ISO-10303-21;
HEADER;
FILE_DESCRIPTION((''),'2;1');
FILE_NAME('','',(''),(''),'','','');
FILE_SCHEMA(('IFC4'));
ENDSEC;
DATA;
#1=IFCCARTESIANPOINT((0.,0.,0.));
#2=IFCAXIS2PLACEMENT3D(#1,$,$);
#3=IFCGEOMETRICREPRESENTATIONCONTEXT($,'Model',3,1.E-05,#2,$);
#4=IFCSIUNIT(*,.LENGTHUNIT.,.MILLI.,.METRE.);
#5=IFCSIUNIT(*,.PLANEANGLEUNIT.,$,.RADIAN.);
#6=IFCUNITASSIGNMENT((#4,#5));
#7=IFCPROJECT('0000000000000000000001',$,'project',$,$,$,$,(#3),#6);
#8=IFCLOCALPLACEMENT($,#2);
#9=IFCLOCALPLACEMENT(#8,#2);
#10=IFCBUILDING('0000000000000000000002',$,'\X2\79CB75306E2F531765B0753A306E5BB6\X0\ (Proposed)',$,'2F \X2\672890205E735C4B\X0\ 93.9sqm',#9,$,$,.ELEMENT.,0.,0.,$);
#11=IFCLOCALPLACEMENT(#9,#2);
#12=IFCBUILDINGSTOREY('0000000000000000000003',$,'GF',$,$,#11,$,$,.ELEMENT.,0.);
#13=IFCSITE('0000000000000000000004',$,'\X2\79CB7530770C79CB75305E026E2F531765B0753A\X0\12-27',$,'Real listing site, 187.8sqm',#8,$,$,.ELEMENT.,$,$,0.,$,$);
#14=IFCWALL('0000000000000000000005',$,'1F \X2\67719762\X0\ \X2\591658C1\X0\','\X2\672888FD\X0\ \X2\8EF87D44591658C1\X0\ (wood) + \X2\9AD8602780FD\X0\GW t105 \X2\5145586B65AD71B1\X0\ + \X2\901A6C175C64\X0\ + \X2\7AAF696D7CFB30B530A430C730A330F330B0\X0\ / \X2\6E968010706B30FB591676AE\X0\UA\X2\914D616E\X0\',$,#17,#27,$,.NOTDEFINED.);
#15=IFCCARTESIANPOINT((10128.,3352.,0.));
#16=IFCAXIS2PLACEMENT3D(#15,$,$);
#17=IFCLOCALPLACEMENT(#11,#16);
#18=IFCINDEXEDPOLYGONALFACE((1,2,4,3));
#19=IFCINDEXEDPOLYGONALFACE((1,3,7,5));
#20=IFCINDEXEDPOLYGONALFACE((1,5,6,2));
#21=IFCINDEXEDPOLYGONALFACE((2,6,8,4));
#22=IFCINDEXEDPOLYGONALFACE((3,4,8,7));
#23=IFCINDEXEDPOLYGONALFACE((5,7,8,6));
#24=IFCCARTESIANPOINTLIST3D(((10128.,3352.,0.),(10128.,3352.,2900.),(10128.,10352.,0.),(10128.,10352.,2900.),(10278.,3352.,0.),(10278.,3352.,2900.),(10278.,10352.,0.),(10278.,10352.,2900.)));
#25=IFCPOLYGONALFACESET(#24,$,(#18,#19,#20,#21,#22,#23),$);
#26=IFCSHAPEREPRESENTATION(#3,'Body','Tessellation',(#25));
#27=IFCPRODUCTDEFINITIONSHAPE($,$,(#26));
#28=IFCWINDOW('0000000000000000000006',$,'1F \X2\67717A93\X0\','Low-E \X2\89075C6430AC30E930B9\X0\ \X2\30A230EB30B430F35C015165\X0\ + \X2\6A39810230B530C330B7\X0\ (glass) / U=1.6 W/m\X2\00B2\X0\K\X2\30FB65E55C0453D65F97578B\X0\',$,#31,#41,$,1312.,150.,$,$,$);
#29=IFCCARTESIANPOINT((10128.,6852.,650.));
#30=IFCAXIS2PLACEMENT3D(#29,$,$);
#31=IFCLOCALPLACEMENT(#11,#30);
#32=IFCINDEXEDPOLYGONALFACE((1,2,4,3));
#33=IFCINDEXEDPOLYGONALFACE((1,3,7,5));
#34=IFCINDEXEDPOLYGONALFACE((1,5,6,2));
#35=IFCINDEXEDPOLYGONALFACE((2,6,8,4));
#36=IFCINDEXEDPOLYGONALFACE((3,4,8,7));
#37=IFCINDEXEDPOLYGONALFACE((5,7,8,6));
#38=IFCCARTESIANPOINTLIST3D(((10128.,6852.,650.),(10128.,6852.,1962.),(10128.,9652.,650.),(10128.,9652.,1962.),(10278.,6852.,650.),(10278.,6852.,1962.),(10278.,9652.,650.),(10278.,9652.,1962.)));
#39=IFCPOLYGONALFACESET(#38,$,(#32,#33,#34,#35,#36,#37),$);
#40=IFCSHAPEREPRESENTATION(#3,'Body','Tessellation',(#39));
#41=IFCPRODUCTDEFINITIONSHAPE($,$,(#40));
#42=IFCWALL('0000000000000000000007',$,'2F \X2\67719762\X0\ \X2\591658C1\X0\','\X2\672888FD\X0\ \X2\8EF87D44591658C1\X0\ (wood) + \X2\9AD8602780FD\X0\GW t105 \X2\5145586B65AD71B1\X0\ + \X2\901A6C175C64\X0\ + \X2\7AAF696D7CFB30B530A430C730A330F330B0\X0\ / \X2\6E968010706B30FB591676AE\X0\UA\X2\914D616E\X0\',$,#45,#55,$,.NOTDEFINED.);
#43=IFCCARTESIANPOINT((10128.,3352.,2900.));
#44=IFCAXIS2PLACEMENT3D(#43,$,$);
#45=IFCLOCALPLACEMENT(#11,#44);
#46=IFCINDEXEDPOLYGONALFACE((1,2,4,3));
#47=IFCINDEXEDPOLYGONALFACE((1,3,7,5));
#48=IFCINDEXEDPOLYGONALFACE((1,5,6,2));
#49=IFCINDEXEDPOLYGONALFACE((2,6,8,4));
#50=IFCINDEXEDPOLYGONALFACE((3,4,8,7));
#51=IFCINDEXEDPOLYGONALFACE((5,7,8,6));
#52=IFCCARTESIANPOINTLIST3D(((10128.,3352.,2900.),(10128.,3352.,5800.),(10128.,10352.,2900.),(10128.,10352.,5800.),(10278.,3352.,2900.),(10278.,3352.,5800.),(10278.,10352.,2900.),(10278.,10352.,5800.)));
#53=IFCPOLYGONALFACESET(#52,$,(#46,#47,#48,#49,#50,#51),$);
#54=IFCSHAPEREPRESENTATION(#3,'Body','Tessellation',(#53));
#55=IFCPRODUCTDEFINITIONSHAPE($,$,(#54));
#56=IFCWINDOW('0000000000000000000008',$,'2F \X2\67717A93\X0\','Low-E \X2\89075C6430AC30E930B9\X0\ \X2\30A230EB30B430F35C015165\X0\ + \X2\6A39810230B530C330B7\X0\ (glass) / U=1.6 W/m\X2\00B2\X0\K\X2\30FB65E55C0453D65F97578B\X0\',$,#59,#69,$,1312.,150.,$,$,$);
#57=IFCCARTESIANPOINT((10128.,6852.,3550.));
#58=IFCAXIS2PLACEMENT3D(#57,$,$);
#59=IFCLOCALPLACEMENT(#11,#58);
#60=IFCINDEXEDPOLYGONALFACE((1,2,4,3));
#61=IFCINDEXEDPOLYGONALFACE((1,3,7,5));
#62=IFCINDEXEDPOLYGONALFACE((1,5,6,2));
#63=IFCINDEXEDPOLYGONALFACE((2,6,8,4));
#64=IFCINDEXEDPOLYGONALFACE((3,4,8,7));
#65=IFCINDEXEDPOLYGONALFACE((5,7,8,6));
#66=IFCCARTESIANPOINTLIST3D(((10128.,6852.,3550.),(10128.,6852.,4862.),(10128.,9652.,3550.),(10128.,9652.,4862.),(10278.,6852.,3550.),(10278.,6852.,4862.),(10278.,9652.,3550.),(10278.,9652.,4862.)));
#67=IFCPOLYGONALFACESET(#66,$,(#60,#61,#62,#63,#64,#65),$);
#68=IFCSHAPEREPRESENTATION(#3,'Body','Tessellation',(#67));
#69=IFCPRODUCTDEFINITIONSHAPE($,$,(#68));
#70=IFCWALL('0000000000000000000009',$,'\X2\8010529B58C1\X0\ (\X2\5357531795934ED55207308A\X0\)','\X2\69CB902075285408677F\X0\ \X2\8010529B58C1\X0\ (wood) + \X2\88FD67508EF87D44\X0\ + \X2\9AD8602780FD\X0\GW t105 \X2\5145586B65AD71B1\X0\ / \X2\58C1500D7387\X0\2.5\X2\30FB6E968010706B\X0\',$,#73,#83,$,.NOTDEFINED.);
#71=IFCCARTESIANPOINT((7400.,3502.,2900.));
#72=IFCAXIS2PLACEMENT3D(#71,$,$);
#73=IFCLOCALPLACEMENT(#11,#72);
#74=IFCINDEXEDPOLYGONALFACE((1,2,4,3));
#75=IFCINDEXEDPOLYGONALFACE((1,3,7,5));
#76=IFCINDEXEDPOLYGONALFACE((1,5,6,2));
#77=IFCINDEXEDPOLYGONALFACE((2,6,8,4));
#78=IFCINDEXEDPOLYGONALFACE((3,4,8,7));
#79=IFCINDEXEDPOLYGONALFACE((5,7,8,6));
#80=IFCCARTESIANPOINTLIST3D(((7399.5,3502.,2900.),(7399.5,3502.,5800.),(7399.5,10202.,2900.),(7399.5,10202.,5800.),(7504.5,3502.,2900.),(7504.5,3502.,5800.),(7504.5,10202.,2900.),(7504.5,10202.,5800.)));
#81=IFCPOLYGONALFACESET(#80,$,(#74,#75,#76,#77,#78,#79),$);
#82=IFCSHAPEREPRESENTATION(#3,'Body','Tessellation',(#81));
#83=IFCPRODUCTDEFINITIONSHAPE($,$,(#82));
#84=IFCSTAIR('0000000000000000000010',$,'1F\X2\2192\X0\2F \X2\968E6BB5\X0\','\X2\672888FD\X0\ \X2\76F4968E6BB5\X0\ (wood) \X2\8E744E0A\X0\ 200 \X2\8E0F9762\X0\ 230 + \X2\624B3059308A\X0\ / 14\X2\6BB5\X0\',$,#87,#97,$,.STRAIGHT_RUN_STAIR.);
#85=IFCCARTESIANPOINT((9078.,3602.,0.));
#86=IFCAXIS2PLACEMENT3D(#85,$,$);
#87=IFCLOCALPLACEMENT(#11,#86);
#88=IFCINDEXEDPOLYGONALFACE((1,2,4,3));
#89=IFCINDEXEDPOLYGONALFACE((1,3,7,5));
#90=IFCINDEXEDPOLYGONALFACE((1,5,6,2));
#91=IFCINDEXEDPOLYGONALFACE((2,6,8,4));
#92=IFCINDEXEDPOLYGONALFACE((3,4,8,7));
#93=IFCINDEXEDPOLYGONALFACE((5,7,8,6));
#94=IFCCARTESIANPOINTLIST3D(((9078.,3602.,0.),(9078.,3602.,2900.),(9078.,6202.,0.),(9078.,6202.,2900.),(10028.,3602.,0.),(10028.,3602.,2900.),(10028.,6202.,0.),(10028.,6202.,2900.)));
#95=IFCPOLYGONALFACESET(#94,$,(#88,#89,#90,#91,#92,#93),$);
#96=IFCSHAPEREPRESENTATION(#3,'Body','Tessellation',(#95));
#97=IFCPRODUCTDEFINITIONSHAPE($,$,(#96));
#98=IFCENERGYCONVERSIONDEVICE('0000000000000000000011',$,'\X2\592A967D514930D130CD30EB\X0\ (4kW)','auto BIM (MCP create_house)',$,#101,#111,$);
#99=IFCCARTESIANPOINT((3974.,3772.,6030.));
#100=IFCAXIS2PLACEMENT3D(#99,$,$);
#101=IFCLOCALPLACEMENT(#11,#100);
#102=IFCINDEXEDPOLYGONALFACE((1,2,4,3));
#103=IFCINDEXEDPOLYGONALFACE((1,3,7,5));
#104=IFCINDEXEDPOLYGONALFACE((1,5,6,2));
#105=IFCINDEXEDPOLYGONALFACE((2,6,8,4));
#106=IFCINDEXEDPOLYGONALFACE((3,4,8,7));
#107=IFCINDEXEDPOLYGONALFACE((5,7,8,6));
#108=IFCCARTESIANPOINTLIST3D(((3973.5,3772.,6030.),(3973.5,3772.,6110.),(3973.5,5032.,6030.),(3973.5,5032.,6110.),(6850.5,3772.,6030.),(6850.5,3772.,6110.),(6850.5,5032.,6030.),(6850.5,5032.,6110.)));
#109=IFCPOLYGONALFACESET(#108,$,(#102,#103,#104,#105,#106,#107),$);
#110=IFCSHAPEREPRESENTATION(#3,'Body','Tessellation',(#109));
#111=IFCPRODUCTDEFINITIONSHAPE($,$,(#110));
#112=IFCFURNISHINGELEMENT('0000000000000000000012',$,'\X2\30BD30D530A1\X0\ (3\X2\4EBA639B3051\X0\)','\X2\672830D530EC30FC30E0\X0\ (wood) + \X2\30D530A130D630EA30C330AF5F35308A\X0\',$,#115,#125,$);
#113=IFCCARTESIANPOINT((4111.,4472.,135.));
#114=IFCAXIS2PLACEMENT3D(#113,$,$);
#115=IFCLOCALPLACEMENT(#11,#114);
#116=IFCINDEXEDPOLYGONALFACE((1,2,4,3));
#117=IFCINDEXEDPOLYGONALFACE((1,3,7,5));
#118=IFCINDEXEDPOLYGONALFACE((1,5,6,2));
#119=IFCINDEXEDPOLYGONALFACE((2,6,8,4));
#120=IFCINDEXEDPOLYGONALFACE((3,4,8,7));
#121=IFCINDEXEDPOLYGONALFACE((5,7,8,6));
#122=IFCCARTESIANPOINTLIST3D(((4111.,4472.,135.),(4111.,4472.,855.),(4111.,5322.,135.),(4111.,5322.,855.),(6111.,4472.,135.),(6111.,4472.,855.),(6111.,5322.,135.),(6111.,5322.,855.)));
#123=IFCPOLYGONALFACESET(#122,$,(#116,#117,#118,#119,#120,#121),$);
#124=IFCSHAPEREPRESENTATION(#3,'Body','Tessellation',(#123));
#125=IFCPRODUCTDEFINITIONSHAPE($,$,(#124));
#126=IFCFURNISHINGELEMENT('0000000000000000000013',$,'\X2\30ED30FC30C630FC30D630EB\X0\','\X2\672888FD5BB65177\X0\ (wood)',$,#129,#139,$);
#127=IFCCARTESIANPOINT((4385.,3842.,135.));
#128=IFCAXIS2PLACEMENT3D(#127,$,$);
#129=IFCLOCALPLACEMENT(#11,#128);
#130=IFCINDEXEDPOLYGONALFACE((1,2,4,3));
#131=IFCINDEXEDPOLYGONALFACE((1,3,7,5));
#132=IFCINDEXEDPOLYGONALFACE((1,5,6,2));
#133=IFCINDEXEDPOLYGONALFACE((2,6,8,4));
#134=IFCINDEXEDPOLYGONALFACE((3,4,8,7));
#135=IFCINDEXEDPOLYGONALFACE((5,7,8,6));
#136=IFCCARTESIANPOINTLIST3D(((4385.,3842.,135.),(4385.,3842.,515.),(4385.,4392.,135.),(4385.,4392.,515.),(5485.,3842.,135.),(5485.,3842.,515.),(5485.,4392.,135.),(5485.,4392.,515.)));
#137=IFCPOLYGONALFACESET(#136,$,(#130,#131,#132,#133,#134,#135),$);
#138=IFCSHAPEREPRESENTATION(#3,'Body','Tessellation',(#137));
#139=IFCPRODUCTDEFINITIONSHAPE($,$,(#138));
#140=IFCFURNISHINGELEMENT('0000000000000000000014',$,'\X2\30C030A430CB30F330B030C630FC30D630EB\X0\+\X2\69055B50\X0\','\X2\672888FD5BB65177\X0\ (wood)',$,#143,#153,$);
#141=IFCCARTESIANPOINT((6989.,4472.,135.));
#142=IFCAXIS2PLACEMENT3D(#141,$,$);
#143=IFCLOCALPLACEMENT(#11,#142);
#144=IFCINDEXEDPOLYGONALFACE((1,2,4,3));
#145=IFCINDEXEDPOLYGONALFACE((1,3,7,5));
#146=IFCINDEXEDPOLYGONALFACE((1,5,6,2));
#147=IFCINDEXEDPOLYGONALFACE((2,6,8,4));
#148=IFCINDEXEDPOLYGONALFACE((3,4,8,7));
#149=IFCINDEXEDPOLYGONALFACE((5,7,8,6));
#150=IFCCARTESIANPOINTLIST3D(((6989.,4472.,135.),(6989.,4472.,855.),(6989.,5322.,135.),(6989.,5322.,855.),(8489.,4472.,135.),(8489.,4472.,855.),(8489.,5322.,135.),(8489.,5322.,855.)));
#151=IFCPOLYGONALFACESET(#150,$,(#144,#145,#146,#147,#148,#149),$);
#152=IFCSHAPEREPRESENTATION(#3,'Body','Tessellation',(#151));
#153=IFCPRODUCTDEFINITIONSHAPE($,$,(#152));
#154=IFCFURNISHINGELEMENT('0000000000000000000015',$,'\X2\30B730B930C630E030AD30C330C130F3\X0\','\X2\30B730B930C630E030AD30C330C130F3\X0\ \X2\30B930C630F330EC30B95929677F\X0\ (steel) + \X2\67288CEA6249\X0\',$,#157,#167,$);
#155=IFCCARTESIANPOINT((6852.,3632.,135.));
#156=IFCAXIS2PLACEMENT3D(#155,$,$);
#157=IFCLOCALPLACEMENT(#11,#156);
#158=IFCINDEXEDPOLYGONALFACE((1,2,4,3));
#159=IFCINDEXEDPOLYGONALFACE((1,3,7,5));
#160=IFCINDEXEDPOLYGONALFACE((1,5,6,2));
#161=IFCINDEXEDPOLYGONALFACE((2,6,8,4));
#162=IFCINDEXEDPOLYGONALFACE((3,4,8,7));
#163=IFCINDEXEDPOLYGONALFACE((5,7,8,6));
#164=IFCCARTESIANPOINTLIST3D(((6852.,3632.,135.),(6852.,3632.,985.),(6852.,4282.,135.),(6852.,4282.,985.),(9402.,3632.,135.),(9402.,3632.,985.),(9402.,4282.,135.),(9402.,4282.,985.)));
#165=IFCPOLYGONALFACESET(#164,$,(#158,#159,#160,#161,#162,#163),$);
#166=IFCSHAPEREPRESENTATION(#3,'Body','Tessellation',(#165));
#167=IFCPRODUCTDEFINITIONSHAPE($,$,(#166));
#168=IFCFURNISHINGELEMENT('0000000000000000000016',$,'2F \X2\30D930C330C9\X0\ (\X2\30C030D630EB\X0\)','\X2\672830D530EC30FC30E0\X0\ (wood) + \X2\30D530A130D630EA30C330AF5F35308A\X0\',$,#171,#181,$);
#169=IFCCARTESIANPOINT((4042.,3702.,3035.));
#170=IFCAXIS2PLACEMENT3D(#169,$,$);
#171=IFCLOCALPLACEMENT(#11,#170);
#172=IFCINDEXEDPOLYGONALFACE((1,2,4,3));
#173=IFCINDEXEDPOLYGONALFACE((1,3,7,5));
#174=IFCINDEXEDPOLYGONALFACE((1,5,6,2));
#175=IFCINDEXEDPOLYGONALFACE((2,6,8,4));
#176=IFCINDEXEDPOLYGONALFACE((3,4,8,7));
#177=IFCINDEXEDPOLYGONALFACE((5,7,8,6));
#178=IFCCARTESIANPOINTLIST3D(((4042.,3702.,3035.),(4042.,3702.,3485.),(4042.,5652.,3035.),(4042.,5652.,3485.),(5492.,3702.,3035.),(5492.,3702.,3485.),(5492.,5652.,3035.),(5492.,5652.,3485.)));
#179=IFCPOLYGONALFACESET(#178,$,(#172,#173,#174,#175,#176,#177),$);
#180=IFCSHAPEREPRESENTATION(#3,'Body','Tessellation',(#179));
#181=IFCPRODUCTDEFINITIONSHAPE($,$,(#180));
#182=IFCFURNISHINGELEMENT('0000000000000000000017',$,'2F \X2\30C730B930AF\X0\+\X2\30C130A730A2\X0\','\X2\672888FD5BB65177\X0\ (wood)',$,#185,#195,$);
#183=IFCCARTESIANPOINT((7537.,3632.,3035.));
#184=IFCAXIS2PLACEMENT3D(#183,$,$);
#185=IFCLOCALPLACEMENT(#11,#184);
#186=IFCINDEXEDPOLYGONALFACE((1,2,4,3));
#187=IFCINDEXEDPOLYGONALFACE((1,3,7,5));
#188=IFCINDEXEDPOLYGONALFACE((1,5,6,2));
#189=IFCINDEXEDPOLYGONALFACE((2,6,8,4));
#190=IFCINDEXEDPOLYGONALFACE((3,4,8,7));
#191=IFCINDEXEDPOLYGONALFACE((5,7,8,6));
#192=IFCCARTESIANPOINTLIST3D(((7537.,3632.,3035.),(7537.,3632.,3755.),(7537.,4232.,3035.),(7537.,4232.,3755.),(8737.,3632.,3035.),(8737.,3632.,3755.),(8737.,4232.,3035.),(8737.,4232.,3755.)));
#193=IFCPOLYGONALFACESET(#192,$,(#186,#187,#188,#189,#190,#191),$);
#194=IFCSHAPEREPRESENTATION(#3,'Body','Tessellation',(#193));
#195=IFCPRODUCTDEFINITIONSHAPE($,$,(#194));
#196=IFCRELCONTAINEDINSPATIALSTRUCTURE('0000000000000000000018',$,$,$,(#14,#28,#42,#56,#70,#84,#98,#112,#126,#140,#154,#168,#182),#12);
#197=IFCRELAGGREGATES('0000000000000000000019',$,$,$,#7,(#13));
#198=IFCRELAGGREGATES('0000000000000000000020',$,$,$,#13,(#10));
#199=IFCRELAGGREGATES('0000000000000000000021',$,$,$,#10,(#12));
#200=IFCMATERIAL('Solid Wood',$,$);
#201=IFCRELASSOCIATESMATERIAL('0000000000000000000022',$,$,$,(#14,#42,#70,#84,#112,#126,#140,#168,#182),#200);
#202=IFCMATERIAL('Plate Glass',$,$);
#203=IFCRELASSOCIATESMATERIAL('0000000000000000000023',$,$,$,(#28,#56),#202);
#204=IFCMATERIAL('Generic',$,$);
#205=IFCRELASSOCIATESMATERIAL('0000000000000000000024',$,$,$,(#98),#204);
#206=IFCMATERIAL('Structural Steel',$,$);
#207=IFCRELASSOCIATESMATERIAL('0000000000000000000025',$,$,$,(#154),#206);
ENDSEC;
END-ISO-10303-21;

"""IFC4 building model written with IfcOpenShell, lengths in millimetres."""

from ifc_helpers import new_model, si_unit, frame, frame_2d, origin, place, context, project, spatial, rectangle, extrude, material, element, fill, save


model = new_model("IFC4")

# Units and contexts
model_context = context("Model", 3, precision=1e-05, world=origin())
ifc_project = project(units=[si_unit("LENGTHUNIT", "METRE", prefix="MILLI"), si_unit("PLANEANGLEUNIT", "RADIAN")], contexts=[model_context])

# Site, building, storey
site_placement = place(None, origin())
site = spatial("IfcSite", under=ifc_project, at=site_placement, Name="秋田県秋田市港北新町12-27", ObjectType="Real listing site, 187.8sqm", CompositionType="ELEMENT", RefElevation=0.0)
building_placement = place(site_placement, origin())
building = spatial("IfcBuilding", under=site, at=building_placement, Name="秋田港北新町の家 (Proposed)", ObjectType="2F 木造平屋 93.9sqm", CompositionType="ELEMENT", ElevationOfRefHeight=0.0, ElevationOfTerrain=0.0)
storey_placement = place(building_placement, origin())
storey = spatial("IfcBuildingStorey", under=building, at=storey_placement, Name="GF", CompositionType="ELEMENT", Elevation=0.0)

# Wall, opening, window
ifc_material_1 = material(Name="Solid Wood")
wall_1_placement = place(storey_placement, frame((10128.0, 3352.0, 0.0)))
wall_1 = element("IfcWall", 1, at=wall_1_placement, inside=storey, material=ifc_material_1, Name="1F 東面 外壁", Description="木製 軸組外壁 (wood) + 高性能GW t105 充填断熱 + 通気層 + 窯業系サイディング / 準耐火・外皮UA配慮", PredefinedType="NOTDEFINED", context=model_context, shape_type="SweptSolid", body=[
    extrude(rectangle(XDim=150.0, YDim=7000.0, at=frame_2d((75.0, 3500.0))), frame((10128.0, 3352.0, 0.0)), (0.0, 0.0, 1.0), 2900.0),
])
opening_1_placement = place(storey_placement, frame((10128.0, 6852.0, 650.0)))
opening_1 = element("IfcOpeningElement", 2, at=opening_1_placement, cuts=wall_1, PredefinedType="NOTDEFINED", context=model_context, shape_type="SweptSolid", body=[
    extrude(rectangle(XDim=150.0, YDim=2800.0, at=frame_2d((75.0, 1400.0))), frame((10128.0, 6852.0, 650.0)), (0.0, 0.0, 1.0), 1312.0),
])
ifc_material_2 = material(Name="Plate Glass")
window_1_placement = place(storey_placement, frame((10128.0, 6852.0, 650.0)))
window_1 = element("IfcWindow", 3, at=window_1_placement, inside=storey, material=ifc_material_2, Name="1F 東窓", Description="Low-E 複層ガラス アルゴン封入 + 樹脂サッシ (glass) / U=1.6 W/m²K・日射取得型", OverallHeight=1312.0, OverallWidth=150.0, context=model_context, shape_type="SweptSolid", body=[
    extrude(rectangle(XDim=150.0, YDim=2800.0, at=frame_2d((75.0, 1400.0))), frame((10128.0, 6852.0, 650.0)), (0.0, 0.0, 1.0), 1312.0),
])
fill(opening_1, window_1)

# Wall, opening, window
wall_2_placement = place(storey_placement, frame((10128.0, 3352.0, 2900.0)))
wall_2 = element("IfcWall", 4, at=wall_2_placement, inside=storey, material=ifc_material_1, Name="2F 東面 外壁", Description="木製 軸組外壁 (wood) + 高性能GW t105 充填断熱 + 通気層 + 窯業系サイディング / 準耐火・外皮UA配慮", PredefinedType="NOTDEFINED", context=model_context, shape_type="SweptSolid", body=[
    extrude(rectangle(XDim=150.0, YDim=7000.0, at=frame_2d((75.0, 3500.0))), frame((10128.0, 3352.0, 2900.0)), (0.0, 0.0, 1.0), 2900.0),
])
opening_2_placement = place(storey_placement, frame((10128.0, 6852.0, 3550.0)))
opening_2 = element("IfcOpeningElement", 5, at=opening_2_placement, cuts=wall_2, PredefinedType="NOTDEFINED", context=model_context, shape_type="SweptSolid", body=[
    extrude(rectangle(XDim=150.0, YDim=2800.0, at=frame_2d((75.0, 1400.0))), frame((10128.0, 6852.0, 3550.0)), (0.0, 0.0, 1.0), 1312.0),
])
window_2_placement = place(storey_placement, frame((10128.0, 6852.0, 3550.0)))
window_2 = element("IfcWindow", 6, at=window_2_placement, inside=storey, material=ifc_material_2, Name="2F 東窓", Description="Low-E 複層ガラス アルゴン封入 + 樹脂サッシ (glass) / U=1.6 W/m²K・日射取得型", OverallHeight=1312.0, OverallWidth=150.0, context=model_context, shape_type="SweptSolid", body=[
    extrude(rectangle(XDim=150.0, YDim=2800.0, at=frame_2d((75.0, 1400.0))), frame((10128.0, 6852.0, 3550.0)), (0.0, 0.0, 1.0), 1312.0),
])
fill(opening_2, window_2)

# Wall
wall_3_placement = place(storey_placement, frame((7400.0, 3502.0, 2900.0)))
element("IfcWall", 7, at=wall_3_placement, inside=storey, material=ifc_material_1, Name="耐力壁 (南北間仕切り)", Description="構造用合板 耐力壁 (wood) + 製材軸組 + 高性能GW t105 充填断熱 / 壁倍率2.5・準耐火", PredefinedType="NOTDEFINED", context=model_context, shape_type="SweptSolid", body=[
    extrude(rectangle(XDim=105.0, YDim=6700.0, at=frame_2d((52.0, 3350.0))), frame((7400.0, 3502.0, 2900.0)), (0.0, 0.0, 1.0), 2900.0),
])

# Stair
stair_placement = place(storey_placement, frame((9078.0, 3602.0, 0.0)))
element("IfcStair", 8, at=stair_placement, inside=storey, material=ifc_material_1, Name="1F→2F 階段", Description="木製 直階段 (wood) 蹴上 200 踏面 230 + 手すり / 14段", PredefinedType="STRAIGHT_RUN_STAIR", context=model_context, shape_type="SweptSolid", body=[
    extrude(rectangle(XDim=950.0, YDim=2600.0, at=frame_2d((475.0, 1300.0))), frame((9078.0, 3602.0, 0.0)), (0.0, 0.0, 1.0), 2900.0),
])

# Energy conversion device
ifc_material_3 = material(Name="Generic")
energy_conversion_device_placement = place(storey_placement, frame((3974.0, 3772.0, 6030.0)))
element("IfcEnergyConversionDevice", 9, at=energy_conversion_device_placement, inside=storey, material=ifc_material_3, Name="太陽光パネル (4kW)", Description="auto BIM (MCP create_house)", context=model_context, shape_type="SweptSolid", body=[
    extrude(rectangle(XDim=2877.0, YDim=1260.0, at=frame_2d((1438.0, 630.0))), frame((3974.0, 3772.0, 6030.0)), (0.0, 0.0, 1.0), 80.0),
])

# Furnishing elements
furnishing_1_placement = place(storey_placement, frame((4111.0, 4472.0, 135.0)))
element("IfcFurnishingElement", 10, at=furnishing_1_placement, inside=storey, material=ifc_material_1, Name="ソファ (3人掛け)", Description="木フレーム (wood) + ファブリック張り", context=model_context, shape_type="SweptSolid", body=[
    extrude(rectangle(XDim=2000.0, YDim=850.0, at=frame_2d((1000.0, 425.0))), frame((4111.0, 4472.0, 135.0)), (0.0, 0.0, 1.0), 720.0),
])
furnishing_2_placement = place(storey_placement, frame((4385.0, 3842.0, 135.0)))
element("IfcFurnishingElement", 11, at=furnishing_2_placement, inside=storey, material=ifc_material_1, Name="ローテーブル", Description="木製家具 (wood)", context=model_context, shape_type="SweptSolid", body=[
    extrude(rectangle(XDim=1100.0, YDim=550.0, at=frame_2d((550.0, 275.0))), frame((4385.0, 3842.0, 135.0)), (0.0, 0.0, 1.0), 380.0),
])
furnishing_3_placement = place(storey_placement, frame((6989.0, 4472.0, 135.0)))
element("IfcFurnishingElement", 12, at=furnishing_3_placement, inside=storey, material=ifc_material_1, Name="ダイニングテーブル+椅子", Description="木製家具 (wood)", context=model_context, shape_type="SweptSolid", body=[
    extrude(rectangle(XDim=1500.0, YDim=850.0, at=frame_2d((750.0, 425.0))), frame((6989.0, 4472.0, 135.0)), (0.0, 0.0, 1.0), 720.0),
])
ifc_material_4 = material(Name="Structural Steel")
furnishing_4_placement = place(storey_placement, frame((6852.0, 3632.0, 135.0)))
element("IfcFurnishingElement", 13, at=furnishing_4_placement, inside=storey, material=ifc_material_4, Name="システムキッチン", Description="システムキッチン ステンレス天板 (steel) + 木質扉", context=model_context, shape_type="SweptSolid", body=[
    extrude(rectangle(XDim=2550.0, YDim=650.0, at=frame_2d((1275.0, 325.0))), frame((6852.0, 3632.0, 135.0)), (0.0, 0.0, 1.0), 850.0),
])
furnishing_5_placement = place(storey_placement, frame((4042.0, 3702.0, 3035.0)))
element("IfcFurnishingElement", 14, at=furnishing_5_placement, inside=storey, material=ifc_material_1, Name="2F ベッド (ダブル)", Description="木フレーム (wood) + ファブリック張り", context=model_context, shape_type="SweptSolid", body=[
    extrude(rectangle(XDim=1450.0, YDim=1950.0, at=frame_2d((725.0, 975.0))), frame((4042.0, 3702.0, 3035.0)), (0.0, 0.0, 1.0), 450.0),
])
furnishing_6_placement = place(storey_placement, frame((7537.0, 3632.0, 3035.0)))
element("IfcFurnishingElement", 15, at=furnishing_6_placement, inside=storey, material=ifc_material_1, Name="2F デスク+チェア", Description="木製家具 (wood)", context=model_context, shape_type="SweptSolid", body=[
    extrude(rectangle(XDim=1200.0, YDim=600.0, at=frame_2d((600.0, 300.0))), frame((7537.0, 3632.0, 3035.0)), (0.0, 0.0, 1.0), 720.0),
])

save(model, "model.ifc")
